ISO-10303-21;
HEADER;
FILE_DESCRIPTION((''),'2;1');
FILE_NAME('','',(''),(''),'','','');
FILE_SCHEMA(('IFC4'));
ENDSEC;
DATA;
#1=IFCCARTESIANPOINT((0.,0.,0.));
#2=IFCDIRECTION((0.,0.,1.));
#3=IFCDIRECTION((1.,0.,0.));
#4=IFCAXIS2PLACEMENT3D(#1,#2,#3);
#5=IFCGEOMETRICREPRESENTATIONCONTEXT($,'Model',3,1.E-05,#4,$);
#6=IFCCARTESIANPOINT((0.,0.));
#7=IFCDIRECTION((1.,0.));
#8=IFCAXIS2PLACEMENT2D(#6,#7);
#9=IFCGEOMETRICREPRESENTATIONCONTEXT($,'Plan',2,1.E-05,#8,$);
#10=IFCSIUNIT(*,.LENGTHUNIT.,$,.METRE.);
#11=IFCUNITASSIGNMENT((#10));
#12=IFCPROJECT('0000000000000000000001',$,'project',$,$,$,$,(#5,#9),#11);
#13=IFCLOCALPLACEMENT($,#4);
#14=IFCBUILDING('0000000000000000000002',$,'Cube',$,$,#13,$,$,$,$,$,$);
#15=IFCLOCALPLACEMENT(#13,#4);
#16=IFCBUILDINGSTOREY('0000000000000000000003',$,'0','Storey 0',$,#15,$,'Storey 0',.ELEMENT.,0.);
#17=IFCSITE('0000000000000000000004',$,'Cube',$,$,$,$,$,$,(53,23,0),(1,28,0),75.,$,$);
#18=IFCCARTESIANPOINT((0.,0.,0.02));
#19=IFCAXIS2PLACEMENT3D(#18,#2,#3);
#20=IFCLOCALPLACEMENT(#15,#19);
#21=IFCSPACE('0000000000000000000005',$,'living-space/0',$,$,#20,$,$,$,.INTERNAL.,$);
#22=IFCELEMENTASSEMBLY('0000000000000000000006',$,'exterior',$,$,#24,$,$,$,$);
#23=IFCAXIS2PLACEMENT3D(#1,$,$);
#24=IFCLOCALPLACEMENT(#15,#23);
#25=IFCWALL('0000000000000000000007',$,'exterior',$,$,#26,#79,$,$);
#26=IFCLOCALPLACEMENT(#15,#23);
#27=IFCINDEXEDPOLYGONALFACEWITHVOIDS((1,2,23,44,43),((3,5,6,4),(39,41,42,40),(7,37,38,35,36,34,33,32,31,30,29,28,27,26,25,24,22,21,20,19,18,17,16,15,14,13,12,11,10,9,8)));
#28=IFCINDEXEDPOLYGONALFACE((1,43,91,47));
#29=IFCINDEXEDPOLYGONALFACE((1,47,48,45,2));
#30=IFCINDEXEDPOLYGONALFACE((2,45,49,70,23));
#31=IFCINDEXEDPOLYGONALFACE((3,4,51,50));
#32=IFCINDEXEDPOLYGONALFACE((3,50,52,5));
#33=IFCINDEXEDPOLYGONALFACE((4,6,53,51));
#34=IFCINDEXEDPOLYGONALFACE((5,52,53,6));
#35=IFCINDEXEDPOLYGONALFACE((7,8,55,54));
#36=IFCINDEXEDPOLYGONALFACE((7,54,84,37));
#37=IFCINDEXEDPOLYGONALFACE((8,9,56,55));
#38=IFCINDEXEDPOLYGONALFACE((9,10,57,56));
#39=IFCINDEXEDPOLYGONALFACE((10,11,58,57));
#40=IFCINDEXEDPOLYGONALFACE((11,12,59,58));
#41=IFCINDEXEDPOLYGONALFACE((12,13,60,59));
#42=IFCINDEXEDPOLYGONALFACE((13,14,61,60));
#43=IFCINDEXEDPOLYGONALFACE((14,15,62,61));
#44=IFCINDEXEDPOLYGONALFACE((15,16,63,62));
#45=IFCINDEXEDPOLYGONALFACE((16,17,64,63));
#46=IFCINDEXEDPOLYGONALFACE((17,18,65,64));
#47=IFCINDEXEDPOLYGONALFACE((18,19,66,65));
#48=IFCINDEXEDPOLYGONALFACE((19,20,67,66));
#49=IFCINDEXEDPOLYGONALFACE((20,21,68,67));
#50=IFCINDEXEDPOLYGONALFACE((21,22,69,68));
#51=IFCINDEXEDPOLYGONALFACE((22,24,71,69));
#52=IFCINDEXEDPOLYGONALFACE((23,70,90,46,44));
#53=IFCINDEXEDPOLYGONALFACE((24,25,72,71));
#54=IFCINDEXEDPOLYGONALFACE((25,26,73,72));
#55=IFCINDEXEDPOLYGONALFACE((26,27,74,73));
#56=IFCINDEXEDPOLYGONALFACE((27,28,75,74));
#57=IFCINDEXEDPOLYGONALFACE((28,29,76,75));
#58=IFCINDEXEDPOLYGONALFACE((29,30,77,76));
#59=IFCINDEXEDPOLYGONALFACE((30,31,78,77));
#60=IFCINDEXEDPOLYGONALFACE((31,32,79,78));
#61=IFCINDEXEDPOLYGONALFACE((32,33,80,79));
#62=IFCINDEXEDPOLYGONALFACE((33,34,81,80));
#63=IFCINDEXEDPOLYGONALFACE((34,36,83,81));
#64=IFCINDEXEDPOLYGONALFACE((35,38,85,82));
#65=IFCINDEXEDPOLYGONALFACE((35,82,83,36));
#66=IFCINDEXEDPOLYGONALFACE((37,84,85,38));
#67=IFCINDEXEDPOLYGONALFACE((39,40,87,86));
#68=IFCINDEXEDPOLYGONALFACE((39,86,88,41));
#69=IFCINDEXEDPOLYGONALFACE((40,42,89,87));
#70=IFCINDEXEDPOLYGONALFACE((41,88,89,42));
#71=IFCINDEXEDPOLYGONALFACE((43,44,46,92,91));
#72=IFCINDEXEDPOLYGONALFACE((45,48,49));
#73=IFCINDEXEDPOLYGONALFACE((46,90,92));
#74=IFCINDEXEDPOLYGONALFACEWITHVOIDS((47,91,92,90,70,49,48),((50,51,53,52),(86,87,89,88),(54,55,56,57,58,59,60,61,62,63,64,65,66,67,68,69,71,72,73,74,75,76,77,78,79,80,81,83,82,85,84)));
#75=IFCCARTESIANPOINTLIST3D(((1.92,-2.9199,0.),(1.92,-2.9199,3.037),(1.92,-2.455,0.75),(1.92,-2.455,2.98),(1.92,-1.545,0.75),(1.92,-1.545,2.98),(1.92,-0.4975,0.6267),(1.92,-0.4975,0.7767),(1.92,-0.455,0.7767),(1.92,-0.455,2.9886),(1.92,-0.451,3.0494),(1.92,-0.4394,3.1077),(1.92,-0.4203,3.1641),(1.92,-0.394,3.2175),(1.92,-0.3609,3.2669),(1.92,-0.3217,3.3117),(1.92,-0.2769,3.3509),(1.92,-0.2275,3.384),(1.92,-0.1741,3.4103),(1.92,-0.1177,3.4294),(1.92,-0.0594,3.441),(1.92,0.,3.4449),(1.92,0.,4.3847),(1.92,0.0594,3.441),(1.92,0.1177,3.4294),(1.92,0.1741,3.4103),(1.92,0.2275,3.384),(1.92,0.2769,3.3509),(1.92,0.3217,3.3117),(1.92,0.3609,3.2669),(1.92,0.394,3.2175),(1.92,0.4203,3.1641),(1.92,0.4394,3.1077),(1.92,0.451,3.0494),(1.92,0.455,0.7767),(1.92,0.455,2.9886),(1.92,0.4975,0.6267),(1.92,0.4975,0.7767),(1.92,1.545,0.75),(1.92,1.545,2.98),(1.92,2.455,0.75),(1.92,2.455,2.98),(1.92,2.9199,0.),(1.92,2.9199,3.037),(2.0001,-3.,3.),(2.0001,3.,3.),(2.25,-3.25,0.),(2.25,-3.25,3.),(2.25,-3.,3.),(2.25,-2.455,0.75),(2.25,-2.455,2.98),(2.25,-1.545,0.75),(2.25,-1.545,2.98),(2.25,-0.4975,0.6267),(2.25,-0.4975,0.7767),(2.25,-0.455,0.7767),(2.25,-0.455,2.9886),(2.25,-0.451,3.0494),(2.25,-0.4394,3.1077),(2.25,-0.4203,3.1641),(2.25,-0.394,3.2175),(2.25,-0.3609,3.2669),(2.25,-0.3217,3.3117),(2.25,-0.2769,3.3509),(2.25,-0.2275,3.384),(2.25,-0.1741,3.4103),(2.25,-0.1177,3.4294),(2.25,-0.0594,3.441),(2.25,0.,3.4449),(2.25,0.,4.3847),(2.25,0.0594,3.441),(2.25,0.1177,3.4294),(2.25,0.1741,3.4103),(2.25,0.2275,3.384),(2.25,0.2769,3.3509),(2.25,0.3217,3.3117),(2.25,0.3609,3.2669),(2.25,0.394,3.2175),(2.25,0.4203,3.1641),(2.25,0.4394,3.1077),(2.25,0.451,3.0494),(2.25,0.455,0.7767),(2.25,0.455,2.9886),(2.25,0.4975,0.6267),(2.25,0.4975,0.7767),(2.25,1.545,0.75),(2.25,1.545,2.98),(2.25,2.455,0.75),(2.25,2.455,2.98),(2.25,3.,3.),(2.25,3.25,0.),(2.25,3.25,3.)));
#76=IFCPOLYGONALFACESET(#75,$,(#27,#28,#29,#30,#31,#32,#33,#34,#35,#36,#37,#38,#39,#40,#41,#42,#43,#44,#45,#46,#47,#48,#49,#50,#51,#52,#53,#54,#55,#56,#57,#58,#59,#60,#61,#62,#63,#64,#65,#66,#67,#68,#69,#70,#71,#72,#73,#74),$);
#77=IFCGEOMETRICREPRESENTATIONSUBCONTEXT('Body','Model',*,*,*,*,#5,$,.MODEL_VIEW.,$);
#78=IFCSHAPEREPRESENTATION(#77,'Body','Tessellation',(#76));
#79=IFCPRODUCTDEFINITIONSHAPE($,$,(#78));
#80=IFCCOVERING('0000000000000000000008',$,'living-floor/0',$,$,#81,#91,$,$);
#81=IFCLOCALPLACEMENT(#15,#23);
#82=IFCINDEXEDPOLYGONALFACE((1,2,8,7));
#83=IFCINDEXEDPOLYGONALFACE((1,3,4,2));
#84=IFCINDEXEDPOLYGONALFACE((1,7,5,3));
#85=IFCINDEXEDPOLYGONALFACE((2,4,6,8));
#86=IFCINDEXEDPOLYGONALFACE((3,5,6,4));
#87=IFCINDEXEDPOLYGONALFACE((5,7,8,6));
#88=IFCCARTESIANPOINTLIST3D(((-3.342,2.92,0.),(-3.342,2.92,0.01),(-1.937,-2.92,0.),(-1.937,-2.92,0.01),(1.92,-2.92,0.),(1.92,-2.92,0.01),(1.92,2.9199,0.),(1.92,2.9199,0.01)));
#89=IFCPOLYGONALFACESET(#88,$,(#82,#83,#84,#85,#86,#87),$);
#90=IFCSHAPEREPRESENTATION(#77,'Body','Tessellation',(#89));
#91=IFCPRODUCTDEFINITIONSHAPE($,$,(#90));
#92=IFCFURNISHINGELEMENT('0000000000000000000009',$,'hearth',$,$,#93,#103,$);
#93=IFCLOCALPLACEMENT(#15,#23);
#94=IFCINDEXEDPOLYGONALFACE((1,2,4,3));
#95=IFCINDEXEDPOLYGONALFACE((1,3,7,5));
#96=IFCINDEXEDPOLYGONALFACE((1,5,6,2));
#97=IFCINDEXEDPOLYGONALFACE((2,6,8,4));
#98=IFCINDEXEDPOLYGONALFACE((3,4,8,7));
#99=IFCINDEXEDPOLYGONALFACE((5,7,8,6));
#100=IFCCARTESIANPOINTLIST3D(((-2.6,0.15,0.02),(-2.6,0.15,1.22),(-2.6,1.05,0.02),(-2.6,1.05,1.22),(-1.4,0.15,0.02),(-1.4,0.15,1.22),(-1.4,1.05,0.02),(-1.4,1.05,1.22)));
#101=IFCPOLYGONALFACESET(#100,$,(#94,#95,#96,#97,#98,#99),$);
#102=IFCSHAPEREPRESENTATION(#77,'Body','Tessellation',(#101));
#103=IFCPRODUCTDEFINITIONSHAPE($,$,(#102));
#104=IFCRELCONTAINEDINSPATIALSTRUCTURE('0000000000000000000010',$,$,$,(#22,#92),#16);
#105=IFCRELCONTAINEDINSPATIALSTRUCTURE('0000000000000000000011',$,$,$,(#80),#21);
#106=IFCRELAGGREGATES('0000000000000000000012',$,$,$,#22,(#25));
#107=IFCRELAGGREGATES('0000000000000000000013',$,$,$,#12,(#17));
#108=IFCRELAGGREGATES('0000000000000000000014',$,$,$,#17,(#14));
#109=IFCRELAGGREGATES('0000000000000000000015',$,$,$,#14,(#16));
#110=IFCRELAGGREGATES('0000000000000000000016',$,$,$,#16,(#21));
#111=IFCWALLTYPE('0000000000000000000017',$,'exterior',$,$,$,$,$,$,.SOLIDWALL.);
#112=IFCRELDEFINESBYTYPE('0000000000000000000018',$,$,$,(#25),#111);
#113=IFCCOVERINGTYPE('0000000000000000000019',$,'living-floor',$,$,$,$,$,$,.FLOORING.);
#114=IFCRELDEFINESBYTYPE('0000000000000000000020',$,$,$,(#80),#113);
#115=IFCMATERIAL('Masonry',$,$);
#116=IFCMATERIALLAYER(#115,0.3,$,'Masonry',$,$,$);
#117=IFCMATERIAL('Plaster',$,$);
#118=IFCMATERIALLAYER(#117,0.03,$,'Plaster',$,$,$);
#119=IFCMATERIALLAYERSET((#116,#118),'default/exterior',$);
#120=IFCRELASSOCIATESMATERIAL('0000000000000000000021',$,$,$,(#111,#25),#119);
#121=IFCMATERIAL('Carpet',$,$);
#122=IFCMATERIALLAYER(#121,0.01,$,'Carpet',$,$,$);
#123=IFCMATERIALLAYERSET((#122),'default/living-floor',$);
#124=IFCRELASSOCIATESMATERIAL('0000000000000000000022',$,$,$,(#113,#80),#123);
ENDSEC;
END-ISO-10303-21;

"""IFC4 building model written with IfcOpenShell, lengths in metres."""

from ifc_helpers import new_model, si_unit, frame, origin, origin_with_axes, origin_2d_with_axis, place, context, subcontext, project, spatial, polyline, indexed_curve, outline, extrude, clip, bounded_halfspace, material, layer, layer_set, layer_usage, type_object, element, aggregate, save


model = new_model("IFC4")

# Units and contexts
model_context = context("Model", 3, precision=1e-05, world=origin_with_axes())
plan_context = context("Plan", 2, precision=1e-05, world=origin_2d_with_axis())
body_context = subcontext(model_context, "Body", "Model", "MODEL_VIEW")
ifc_project = project(units=[si_unit("LENGTHUNIT", "METRE")], contexts=[model_context, plan_context])

# Site, building, storey
site = spatial("IfcSite", under=ifc_project, Name="Cube", RefLatitude=(53, 23, 0), RefLongitude=(1, 28, 0), RefElevation=75.0)
building_placement = place(None, origin_with_axes())
building = spatial("IfcBuilding", under=site, at=building_placement, Name="Cube")
storey_placement = place(building_placement, origin_with_axes())
storey = spatial("IfcBuildingStorey", under=building, at=storey_placement, Name="0", Description="Storey 0", LongName="Storey 0", CompositionType="ELEMENT", Elevation=0.0)

# Element assembly, wall, openings
ifc_material_1 = material(Name="Masonry")
ifc_layer_1 = layer(ifc_material_1, 0.3, Name="Masonry")
ifc_material_2 = material(Name="Plaster")
ifc_layer_2 = layer(ifc_material_2, 0.03, Name="Plaster")
ifc_layer_set_1 = layer_set([ifc_layer_1, ifc_layer_2], Name="default/exterior")
wall_type = type_object("IfcWallType", Name="exterior", PredefinedType="SOLIDWALL", material=ifc_layer_set_1)
assembly_1_placement = place(storey_placement, frame((2.0, -3.0, 0.0), z_axis=(0.0, 0.0, 1.0), x_axis=(0.0, 1.0, 0.0)))
assembly_1 = element("IfcElementAssembly", 1, at=assembly_1_placement, inside=storey, Name="exterior")
ifc_layer_usage_1 = layer_usage(ifc_layer_set_1, "AXIS2", "POSITIVE", -0.25)
wall_1_placement = place(assembly_1_placement, origin_with_axes())
wall_1 = element("IfcWall", 2, at=wall_1_placement, type_object=wall_type, material=ifc_layer_usage_1, Name="exterior", context=body_context, shape_type="Clipping", body=[
    clip(clip(clip(clip(extrude(outline(polyline([(0.0801, 0.08), (-0.25, -0.25), (6.25, -0.25), (5.9199, 0.08), (0.0801, 0.08)])), origin(), (0.0, 0.0, 1.0), 4.385), bounded_halfspace(frame((6.0, 0.0, 3.0), z_axis=(0.419069, 0.0, 0.907954), x_axis=(0.0, -1.0, 0.0)), False, origin(), polyline([(6.0, -1.0), (3.0, -1.0), (3.0, 1.0), (6.0, 1.0), (6.0, -1.0)]))), bounded_halfspace(frame((6.0, 0.0, 3.0), z_axis=(0.0, 0.0, 1.0), x_axis=(0.0, 1.0, 0.0)), False, origin(), polyline([(6.0, 1.0), (7.0, 1.0), (7.0, -1.0), (6.0, -1.0), (6.0, 1.0)]))), bounded_halfspace(frame((3.0, 0.0, 4.3847), z_axis=(-0.419069, 0.0, 0.907954), x_axis=(0.0, -1.0, 0.0)), False, origin(), polyline([(3.0, -1.0), (0.0, -1.0), (0.0, 1.0), (3.0, 1.0), (3.0, -1.0)]))), bounded_halfspace(frame((0.0, 0.0, 3.0), z_axis=(0.0, 0.0, 1.0), x_axis=(0.0, -1.0, 0.0)), False, origin(), polyline([(0.0, -1.0), (-1.0, -1.0), (-1.0, 1.0), (0.0, 1.0), (0.0, -1.0)]))),
])
opening_1_placement = place(wall_1_placement, frame((0.545, -0.25, 0.75), z_axis=(0.0, 0.0, 1.0), x_axis=(1.0, 0.0, 0.0)))
element("IfcOpeningElement", 3, at=opening_1_placement, cuts=wall_1, PredefinedType="OPENING", context=body_context, shape_type="SweptSolid", body=[
    extrude(outline(polyline([(0.0, -0.02), (0.91, -0.02), (0.91, 0.35), (0.0, 0.35), (0.0, -0.02)])), origin(), (0.0, 0.0, 1.0), 2.23),
])
opening_2_placement = place(wall_1_placement, frame((2.545, -0.25, 0.75), z_axis=(0.0, 0.0, 1.0), x_axis=(1.0, 0.0, 0.0)))
element("IfcOpeningElement", 4, at=opening_2_placement, cuts=wall_1, PredefinedType="OPENING", context=body_context, shape_type="SweptSolid", body=[
    extrude(outline(polyline([(0.1333, 2.5617), (0.1781, 2.6009), (0.2275, 2.634), (0.2809, 2.6603), (0.3373, 2.6794), (0.3956, 2.691), (0.455, 2.6949), (0.5144, 2.691), (0.5727, 2.6794), (0.6291, 2.6603), (0.6825, 2.634), (0.7319, 2.6009), (0.7767, 2.5617), (0.8159, 2.5169), (0.849, 2.4675), (0.8753, 2.4141), (0.8944, 2.3577), (0.906, 2.2994), (0.91, 2.2386), (0.91, 2.2069), (0.91, 0.0267), (0.9525, 0.0267), (0.9525, -0.1233), (-0.0425, -0.1233), (-0.0425, 0.0267), (0.0, 0.0267), (0.0, 2.2069), (0.0, 2.2386), (0.004, 2.2994), (0.0156, 2.3577), (0.0347, 2.4141), (0.061, 2.4675), (0.0941, 2.5169), (0.1333, 2.5617)])), frame((0.0, -0.02, 0.0), z_axis=(0.0, -1.0, 0.0), x_axis=(1.0, 0.0, 0.0)), (0.0, 0.0, -1.0), 0.37),
])
opening_3_placement = place(wall_1_placement, frame((4.545, -0.25, 0.75), z_axis=(0.0, 0.0, 1.0), x_axis=(1.0, 0.0, 0.0)))
element("IfcOpeningElement", 5, at=opening_3_placement, cuts=wall_1, PredefinedType="OPENING", context=body_context, shape_type="SweptSolid", body=[
    extrude(outline(polyline([(0.0, -0.02), (0.91, -0.02), (0.91, 0.35), (0.0, 0.35), (0.0, -0.02)])), origin(), (0.0, 0.0, 1.0), 2.23),
])
aggregate(assembly_1, [wall_1])

# Shared definitions
space_placement = place(storey_placement, frame((0.0, 0.0, 0.02), z_axis=(0.0, 0.0, 1.0), x_axis=(1.0, 0.0, 0.0)))
space = spatial("IfcSpace", under=storey, at=space_placement, Name="living-space/0", PredefinedType="INTERNAL")

# Covering
ifc_material_3 = material(Name="Carpet")
ifc_layer_3 = layer(ifc_material_3, 0.01, Name="Carpet")
ifc_layer_set_2 = layer_set([ifc_layer_3], Name="default/living-floor")
ifc_layer_usage_2 = layer_usage(ifc_layer_set_2, "AXIS3", "POSITIVE", 0.0)
covering_type = type_object("IfcCoveringType", Name="living-floor", PredefinedType="FLOORING", material=ifc_layer_set_2)
covering_placement = place(space_placement, frame((0.0, 0.0, -0.02), z_axis=(0.0, 0.0, 1.0), x_axis=(1.0, 0.0, 0.0)))
element("IfcCovering", 6, at=covering_placement, inside=space, type_object=covering_type, material=ifc_layer_usage_2, Name="living-floor/0", context=body_context, shape_type="SweptSolid", body=[
    extrude(outline(polyline([(1.92, 2.9199), (-3.342, 2.92), (-1.937, -2.92), (1.92, -2.92), (1.92, 2.9199)])), origin_with_axes(), (0.0, 0.0, 1.0), 0.01),
])

# Furnishing element
furnishing_placement = place(storey_placement, frame((-2.6, 0.15, 0.02), z_axis=(0.0, 0.0, 1.0), x_axis=(1.0, 0.0, 0.0)))
element("IfcFurnishingElement", 7, at=furnishing_placement, inside=storey, Name="hearth", context=body_context, shape_type="SweptSolid", body=[
    extrude(outline(indexed_curve([(0.0, 0.0), (1.2, 0.0), (1.2, 0.9), (0.0, 0.9)])), None, (0.0, 0.0, 1.0), 1.2),
])

save(model, "model.ifc")
